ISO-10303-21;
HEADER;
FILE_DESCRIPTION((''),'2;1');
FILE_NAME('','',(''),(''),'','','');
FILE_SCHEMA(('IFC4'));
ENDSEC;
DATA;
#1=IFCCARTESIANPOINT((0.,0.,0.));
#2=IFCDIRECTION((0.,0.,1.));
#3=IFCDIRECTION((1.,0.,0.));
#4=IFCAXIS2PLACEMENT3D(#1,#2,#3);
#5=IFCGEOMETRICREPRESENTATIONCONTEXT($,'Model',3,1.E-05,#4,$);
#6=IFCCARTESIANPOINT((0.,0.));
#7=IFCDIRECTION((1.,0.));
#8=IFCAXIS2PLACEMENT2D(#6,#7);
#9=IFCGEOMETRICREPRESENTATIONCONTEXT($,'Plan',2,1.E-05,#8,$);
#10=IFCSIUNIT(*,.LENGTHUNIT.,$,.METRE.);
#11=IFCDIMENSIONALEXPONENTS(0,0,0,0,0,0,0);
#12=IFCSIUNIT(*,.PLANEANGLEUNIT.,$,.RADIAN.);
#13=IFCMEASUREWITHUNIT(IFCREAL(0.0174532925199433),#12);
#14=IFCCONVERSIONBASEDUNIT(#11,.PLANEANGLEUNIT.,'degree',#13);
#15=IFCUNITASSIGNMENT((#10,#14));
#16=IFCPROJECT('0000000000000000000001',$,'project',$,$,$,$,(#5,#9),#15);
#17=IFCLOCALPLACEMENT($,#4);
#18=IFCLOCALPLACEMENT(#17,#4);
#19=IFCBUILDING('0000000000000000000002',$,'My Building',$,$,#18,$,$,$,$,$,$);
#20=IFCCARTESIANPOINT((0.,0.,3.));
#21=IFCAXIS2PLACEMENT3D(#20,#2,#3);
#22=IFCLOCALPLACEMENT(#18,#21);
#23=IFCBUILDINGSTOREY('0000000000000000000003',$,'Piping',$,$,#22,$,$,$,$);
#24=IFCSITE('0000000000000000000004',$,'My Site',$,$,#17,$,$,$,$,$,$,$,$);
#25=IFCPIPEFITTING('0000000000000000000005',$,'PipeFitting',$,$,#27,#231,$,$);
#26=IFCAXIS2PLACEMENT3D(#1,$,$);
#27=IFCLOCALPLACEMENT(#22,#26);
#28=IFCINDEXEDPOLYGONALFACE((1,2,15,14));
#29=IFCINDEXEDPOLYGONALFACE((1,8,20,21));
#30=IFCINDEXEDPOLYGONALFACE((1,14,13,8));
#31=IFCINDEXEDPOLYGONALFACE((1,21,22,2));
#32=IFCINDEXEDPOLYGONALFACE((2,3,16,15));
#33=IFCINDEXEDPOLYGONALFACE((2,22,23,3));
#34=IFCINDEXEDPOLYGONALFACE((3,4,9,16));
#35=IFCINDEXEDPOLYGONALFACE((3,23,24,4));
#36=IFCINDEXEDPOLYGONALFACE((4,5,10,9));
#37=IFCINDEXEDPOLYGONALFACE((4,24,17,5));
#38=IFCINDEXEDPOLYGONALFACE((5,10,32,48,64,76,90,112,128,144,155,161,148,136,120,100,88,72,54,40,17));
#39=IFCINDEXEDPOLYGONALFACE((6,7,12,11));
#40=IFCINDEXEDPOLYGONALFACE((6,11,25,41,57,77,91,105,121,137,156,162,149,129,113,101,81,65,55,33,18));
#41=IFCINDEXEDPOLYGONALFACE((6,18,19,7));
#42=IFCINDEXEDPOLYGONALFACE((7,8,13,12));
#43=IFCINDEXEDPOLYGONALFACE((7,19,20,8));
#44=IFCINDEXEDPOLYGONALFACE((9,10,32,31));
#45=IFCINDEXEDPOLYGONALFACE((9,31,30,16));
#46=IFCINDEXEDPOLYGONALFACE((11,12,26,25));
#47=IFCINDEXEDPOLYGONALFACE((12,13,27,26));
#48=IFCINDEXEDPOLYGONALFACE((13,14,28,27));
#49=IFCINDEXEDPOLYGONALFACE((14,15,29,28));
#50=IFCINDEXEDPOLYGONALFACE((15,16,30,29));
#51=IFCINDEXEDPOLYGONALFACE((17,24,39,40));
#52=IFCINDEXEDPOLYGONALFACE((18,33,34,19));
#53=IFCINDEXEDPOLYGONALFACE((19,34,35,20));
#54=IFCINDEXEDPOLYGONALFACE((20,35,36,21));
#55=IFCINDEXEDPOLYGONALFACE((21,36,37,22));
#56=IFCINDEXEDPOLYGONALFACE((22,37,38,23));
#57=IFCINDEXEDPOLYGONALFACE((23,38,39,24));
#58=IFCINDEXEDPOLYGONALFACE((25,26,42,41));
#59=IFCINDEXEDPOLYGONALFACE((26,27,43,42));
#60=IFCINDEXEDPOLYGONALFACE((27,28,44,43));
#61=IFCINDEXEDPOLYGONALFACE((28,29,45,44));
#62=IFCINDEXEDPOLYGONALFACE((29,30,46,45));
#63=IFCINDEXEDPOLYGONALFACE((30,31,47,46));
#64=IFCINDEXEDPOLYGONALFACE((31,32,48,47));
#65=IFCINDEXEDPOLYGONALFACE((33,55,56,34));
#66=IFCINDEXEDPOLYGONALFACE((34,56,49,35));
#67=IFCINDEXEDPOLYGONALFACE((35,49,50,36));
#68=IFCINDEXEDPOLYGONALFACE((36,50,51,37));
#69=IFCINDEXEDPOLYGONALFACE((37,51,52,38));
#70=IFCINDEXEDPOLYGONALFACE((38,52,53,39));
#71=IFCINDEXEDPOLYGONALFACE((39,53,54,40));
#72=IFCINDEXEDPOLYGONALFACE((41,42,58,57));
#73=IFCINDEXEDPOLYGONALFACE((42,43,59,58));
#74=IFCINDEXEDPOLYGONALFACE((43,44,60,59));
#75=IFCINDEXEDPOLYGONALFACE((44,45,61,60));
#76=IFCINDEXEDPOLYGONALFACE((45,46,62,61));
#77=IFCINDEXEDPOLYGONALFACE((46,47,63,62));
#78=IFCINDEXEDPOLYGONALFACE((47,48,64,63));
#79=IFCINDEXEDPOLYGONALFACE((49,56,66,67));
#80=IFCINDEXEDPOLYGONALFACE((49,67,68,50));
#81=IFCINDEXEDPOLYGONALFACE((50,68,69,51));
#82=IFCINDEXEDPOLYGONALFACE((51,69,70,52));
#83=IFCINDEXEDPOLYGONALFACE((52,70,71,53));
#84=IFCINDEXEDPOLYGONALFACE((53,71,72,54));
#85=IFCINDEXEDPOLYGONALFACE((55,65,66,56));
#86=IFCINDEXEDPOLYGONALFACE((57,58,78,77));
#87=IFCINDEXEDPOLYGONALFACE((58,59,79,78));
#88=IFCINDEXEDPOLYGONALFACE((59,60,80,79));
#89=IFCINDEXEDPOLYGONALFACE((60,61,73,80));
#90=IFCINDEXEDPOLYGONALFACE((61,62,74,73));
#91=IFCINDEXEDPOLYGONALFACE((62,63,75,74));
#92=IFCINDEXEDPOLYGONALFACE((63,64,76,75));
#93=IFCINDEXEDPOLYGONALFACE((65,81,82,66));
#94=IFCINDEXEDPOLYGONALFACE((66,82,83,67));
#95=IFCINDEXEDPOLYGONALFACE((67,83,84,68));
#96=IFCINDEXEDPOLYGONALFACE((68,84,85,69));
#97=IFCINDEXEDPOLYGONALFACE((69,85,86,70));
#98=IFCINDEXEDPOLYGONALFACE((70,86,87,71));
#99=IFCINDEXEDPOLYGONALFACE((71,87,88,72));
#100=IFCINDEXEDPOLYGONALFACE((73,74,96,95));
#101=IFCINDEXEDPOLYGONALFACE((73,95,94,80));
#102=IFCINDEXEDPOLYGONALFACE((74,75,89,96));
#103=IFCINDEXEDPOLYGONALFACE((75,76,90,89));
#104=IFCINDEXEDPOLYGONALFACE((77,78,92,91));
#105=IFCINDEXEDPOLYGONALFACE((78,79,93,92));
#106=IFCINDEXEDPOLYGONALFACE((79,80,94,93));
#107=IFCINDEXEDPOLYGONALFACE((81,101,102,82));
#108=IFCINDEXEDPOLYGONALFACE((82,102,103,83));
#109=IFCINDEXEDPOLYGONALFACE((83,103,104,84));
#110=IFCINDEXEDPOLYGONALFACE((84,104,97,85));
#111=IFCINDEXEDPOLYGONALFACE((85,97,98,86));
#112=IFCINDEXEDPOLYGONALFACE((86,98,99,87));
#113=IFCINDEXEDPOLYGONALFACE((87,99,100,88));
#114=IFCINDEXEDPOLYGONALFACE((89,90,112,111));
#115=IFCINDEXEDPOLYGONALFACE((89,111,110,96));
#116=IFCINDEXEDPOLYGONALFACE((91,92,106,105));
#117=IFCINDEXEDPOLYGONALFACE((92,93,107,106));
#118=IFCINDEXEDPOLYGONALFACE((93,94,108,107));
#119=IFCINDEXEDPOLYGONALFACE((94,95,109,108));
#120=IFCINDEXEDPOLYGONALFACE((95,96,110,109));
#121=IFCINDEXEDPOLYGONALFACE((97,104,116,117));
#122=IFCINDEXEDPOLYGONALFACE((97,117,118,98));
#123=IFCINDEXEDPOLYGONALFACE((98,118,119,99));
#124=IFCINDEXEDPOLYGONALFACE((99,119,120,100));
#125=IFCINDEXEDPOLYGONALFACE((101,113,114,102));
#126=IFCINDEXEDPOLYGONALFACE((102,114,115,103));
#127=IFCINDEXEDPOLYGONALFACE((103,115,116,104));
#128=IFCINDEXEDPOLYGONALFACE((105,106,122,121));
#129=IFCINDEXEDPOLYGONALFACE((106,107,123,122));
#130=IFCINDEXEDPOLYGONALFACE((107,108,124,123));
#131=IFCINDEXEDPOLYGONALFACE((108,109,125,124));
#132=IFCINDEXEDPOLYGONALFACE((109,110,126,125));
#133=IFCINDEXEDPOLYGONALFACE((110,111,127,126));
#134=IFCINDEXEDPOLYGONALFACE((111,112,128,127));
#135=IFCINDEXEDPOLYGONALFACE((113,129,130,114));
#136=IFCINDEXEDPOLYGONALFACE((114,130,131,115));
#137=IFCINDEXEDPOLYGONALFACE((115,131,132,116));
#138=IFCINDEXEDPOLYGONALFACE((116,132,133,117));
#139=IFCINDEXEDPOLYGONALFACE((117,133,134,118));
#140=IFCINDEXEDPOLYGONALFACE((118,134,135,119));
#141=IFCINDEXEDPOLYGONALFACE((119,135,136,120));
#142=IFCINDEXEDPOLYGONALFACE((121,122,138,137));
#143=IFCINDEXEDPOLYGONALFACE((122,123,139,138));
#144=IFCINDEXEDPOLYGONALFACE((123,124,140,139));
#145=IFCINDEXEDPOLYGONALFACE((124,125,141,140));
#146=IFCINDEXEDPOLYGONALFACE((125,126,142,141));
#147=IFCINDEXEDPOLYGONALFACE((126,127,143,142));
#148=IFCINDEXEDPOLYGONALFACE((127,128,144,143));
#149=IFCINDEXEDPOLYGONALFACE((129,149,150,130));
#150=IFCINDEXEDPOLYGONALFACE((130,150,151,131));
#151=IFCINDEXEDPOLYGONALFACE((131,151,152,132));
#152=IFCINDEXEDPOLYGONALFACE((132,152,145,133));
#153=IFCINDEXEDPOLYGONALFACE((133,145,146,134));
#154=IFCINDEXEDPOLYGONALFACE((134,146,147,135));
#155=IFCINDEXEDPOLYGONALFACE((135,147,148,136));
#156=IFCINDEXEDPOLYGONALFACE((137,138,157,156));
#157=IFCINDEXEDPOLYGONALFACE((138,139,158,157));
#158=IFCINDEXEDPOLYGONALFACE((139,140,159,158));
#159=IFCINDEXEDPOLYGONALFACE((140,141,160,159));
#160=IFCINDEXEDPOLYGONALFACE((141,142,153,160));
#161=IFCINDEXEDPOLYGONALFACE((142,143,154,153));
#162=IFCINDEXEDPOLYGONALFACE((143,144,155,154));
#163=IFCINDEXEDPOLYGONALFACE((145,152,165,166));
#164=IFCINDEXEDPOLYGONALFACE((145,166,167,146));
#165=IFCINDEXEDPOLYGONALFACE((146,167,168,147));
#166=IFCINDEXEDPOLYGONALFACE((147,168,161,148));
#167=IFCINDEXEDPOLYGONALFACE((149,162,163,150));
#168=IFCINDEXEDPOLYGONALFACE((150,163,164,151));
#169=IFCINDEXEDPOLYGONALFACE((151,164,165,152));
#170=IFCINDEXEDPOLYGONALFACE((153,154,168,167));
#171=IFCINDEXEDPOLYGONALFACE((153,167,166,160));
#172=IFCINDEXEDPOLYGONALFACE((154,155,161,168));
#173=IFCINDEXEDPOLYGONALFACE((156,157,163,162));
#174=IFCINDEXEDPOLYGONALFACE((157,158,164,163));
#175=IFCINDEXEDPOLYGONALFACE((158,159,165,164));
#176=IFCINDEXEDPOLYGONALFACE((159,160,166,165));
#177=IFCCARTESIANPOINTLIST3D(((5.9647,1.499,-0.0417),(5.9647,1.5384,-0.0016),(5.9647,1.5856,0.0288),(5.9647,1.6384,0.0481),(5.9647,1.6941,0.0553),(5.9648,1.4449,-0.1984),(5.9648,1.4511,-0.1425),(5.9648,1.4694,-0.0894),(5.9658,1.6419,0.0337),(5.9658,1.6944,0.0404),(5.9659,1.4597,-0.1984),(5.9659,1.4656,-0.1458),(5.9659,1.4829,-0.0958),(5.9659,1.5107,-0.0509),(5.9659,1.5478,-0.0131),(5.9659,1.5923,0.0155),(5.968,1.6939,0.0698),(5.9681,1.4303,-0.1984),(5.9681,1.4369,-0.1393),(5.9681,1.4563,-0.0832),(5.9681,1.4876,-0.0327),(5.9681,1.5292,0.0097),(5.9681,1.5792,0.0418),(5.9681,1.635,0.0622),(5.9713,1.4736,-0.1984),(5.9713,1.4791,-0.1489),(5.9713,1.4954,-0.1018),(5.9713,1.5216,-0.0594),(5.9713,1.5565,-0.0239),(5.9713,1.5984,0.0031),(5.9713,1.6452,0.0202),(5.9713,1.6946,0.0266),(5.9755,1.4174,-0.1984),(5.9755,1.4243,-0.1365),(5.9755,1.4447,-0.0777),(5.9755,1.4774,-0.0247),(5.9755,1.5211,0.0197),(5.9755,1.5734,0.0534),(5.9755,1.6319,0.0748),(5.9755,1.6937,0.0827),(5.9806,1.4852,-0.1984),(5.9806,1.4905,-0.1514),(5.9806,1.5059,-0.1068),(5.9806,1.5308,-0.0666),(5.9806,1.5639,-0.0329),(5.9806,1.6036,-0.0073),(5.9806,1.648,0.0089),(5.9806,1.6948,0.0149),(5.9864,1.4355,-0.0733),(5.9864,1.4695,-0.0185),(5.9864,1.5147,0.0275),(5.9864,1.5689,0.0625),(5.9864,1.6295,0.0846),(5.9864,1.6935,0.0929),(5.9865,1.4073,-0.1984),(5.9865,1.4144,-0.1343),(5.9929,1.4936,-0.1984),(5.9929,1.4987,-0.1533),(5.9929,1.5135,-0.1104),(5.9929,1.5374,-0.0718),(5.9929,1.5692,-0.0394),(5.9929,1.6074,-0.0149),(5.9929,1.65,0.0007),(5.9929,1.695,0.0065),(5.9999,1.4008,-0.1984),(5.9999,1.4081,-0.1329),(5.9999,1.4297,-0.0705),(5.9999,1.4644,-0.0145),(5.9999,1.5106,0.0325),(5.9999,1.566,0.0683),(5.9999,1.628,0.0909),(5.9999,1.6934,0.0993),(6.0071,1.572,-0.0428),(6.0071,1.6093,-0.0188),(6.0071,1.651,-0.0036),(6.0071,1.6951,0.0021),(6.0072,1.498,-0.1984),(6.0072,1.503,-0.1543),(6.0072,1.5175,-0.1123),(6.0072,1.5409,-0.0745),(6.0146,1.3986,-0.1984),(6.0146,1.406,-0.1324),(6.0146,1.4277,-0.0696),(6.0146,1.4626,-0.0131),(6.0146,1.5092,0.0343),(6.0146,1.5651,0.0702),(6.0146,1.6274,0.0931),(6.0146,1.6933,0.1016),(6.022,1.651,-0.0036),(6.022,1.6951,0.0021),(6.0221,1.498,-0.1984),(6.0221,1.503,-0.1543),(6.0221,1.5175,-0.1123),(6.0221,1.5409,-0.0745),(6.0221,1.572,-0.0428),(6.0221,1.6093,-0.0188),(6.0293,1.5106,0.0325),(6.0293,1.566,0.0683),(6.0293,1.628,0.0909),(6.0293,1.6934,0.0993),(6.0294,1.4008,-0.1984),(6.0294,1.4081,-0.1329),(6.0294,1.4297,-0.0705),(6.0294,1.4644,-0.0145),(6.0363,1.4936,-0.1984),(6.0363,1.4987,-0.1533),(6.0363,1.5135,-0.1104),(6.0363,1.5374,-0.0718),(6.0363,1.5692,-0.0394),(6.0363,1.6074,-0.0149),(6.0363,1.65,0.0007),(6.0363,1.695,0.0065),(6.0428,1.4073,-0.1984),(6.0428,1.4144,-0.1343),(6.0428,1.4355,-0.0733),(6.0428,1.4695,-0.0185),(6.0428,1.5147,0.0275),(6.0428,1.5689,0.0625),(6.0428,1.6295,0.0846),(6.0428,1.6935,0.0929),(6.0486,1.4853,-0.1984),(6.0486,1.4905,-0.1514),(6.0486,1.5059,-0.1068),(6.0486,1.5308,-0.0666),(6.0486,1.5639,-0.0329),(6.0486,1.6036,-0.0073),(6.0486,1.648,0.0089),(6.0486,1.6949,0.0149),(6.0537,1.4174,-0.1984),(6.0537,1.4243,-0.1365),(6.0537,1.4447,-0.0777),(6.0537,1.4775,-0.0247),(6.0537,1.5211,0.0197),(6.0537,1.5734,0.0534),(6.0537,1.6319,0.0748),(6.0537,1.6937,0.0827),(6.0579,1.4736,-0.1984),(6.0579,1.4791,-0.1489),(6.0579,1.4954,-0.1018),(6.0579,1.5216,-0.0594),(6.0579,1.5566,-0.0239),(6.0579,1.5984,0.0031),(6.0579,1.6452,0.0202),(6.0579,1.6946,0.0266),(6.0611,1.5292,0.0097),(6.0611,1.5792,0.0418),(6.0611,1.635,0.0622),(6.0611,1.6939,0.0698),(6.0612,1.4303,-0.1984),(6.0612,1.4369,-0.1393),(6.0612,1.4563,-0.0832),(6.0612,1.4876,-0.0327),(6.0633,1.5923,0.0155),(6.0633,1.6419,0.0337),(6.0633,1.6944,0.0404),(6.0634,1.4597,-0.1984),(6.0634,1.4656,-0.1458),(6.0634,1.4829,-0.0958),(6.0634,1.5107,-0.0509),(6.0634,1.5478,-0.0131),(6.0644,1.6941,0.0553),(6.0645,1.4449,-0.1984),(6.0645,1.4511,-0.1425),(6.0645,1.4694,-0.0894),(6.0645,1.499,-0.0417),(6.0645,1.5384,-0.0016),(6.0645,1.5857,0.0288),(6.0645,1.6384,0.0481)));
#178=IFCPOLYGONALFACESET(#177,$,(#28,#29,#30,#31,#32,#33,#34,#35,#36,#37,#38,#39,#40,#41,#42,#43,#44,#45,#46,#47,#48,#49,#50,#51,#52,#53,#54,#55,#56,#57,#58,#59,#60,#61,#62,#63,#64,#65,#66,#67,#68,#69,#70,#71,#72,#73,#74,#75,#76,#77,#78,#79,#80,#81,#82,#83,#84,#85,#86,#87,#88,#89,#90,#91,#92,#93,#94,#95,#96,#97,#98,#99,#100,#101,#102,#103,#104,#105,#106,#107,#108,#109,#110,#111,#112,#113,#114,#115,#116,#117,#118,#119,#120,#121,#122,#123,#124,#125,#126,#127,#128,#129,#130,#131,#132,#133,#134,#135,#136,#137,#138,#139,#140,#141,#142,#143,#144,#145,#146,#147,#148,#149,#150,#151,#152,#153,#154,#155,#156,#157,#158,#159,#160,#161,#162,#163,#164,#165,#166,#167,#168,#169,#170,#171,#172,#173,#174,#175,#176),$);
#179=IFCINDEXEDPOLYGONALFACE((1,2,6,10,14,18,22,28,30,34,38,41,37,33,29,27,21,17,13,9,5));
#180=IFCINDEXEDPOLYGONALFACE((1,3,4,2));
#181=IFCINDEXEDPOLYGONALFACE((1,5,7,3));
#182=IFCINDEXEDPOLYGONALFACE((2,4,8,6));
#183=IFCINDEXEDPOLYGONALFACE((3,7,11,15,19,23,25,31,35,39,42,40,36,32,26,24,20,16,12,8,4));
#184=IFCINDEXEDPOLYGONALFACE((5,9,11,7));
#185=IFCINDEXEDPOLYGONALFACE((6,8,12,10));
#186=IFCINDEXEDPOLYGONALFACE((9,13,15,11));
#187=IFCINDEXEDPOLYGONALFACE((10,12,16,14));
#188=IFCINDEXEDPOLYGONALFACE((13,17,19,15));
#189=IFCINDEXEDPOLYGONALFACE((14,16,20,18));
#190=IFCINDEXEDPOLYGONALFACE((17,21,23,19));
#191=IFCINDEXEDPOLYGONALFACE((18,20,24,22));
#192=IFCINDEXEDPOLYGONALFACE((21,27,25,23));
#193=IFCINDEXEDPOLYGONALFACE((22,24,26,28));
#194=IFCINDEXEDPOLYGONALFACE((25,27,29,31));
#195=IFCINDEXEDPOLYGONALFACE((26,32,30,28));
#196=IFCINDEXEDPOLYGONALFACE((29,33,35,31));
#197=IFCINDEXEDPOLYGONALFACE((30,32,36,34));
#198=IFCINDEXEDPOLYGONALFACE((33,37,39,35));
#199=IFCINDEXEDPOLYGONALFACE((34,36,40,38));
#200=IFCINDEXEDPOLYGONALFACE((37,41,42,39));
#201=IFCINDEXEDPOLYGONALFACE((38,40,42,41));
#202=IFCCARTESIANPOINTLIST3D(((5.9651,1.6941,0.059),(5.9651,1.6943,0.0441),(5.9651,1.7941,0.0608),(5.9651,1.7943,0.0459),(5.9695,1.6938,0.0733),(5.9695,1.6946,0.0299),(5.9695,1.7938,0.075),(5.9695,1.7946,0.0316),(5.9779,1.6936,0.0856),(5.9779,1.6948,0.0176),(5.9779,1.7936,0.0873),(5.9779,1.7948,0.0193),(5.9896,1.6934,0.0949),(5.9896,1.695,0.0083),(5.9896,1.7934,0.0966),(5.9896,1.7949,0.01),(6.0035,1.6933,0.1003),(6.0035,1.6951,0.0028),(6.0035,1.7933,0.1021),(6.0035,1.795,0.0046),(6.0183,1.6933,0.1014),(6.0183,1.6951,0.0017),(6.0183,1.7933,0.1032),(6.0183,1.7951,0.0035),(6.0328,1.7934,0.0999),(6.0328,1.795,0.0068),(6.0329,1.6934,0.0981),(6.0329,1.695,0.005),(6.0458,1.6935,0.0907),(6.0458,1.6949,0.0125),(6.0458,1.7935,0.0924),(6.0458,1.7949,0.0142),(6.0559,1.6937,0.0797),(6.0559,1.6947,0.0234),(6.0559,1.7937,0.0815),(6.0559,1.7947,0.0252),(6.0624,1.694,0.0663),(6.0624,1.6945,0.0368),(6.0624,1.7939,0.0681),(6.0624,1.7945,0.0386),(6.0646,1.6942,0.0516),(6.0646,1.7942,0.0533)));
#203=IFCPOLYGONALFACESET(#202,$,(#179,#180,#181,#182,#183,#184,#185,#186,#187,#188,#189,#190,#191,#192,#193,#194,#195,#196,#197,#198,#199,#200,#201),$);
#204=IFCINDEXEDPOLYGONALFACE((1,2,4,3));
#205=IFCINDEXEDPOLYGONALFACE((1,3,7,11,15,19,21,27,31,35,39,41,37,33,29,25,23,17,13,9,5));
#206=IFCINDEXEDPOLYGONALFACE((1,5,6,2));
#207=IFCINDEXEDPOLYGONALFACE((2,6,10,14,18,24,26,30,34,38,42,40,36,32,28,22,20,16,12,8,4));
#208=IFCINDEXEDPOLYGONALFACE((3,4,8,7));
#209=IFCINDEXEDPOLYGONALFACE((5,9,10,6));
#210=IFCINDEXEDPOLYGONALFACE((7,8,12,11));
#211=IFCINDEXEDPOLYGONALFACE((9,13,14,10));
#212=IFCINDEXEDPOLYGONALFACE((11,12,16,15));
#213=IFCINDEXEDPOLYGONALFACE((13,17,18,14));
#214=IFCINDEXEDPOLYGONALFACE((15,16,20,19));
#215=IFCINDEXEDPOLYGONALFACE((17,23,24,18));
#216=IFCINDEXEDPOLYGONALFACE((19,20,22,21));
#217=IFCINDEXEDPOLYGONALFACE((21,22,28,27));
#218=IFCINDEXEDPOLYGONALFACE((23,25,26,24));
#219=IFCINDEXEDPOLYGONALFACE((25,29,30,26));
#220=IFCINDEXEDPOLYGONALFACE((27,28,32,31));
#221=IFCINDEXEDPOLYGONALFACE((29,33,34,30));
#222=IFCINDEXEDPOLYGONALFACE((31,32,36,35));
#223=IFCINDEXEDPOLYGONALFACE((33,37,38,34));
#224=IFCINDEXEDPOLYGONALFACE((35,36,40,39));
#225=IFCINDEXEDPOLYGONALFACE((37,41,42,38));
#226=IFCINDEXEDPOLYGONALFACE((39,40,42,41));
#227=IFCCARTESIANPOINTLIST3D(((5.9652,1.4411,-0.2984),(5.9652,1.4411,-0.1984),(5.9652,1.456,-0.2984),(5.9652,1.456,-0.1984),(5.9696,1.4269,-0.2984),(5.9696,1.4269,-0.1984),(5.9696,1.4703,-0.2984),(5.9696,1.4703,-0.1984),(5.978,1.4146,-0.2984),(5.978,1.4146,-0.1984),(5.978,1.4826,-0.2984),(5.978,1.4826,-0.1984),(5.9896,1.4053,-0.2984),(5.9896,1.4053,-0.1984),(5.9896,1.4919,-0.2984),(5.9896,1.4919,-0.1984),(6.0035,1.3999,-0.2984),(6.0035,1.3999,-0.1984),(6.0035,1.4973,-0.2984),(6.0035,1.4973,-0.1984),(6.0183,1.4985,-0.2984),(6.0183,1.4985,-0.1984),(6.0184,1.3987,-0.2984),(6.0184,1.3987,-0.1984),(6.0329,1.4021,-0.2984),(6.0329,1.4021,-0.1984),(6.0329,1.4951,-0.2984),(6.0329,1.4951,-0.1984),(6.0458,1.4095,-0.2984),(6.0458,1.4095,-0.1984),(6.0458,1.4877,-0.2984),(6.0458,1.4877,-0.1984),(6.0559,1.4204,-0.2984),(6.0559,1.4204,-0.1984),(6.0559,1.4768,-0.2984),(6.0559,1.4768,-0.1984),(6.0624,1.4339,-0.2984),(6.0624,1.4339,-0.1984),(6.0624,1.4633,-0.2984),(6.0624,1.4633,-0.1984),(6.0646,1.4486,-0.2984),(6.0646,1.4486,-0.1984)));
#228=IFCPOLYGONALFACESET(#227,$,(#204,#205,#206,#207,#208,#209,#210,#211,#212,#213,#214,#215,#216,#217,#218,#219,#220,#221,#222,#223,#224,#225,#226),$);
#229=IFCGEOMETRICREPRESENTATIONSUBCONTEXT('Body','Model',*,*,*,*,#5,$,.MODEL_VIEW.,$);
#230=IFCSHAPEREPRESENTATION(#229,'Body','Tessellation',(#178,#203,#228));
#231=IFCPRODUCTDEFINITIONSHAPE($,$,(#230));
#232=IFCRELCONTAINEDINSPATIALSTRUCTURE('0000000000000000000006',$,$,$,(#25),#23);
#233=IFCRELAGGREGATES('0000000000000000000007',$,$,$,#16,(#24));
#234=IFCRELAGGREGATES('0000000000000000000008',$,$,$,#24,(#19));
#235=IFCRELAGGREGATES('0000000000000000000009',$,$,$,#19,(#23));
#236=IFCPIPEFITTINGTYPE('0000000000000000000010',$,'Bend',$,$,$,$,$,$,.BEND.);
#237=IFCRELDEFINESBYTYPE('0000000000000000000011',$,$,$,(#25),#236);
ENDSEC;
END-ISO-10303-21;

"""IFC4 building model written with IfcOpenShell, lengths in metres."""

from ifc_helpers import new_model, entity, si_unit, converted_unit, frame, origin_with_axes, origin_2d_with_axis, place, context, subcontext, project, spatial, circle, extrude, source, transform, mapped, type_object, type_shapes, element, save


model = new_model("IFC4")

# Units and contexts
model_context = context("Model", 3, precision=1e-05, world=origin_with_axes())
plan_context = context("Plan", 2, precision=1e-05, world=origin_2d_with_axis())
body_context = subcontext(model_context, "Body", "Model", "MODEL_VIEW")
ifc_project = project(units=[si_unit("LENGTHUNIT", "METRE"), converted_unit("PLANEANGLEUNIT", "degree", entity("IfcReal", 0.0174532925199433), si_unit("PLANEANGLEUNIT", "RADIAN"), dimensions=[0, 0, 0, 0, 0, 0, 0])], contexts=[model_context, plan_context])

# Site, building, storey
site_placement = place(None, origin_with_axes())
site = spatial("IfcSite", under=ifc_project, at=site_placement, Name="My Site")
building_placement = place(site_placement, origin_with_axes())
building = spatial("IfcBuilding", under=site, at=building_placement, Name="My Building")
storey_placement = place(building_placement, frame((0.0, 0.0, 3.0), z_axis=(0.0, 0.0, 1.0), x_axis=(1.0, 0.0, 0.0)))
storey = spatial("IfcBuildingStorey", under=building, at=storey_placement, Name="Piping")

# Pipe fitting
pipe_fitting_type_1 = type_object("IfcPipeFittingType", Name="Bend", PredefinedType="BEND")
shared_shape_1 = source(origin_with_axes(), body_context, "Body", "SolidModel", [
    entity("IfcSweptDiskSolid", entity("IfcIndexedPolyCurve", entity("IfcCartesianPointList3D", [[0.0, 0.0, 0.1], [0.0, -0.0717, 0.2752], [0.0, -0.2456, 0.35]]), [entity("IfcArcIndex", [1, 2, 3])]), 0.05),
    extrude(circle(Radius=0.05), origin_with_axes(), (0.0, 0.0, 1.0), 0.1),
    extrude(circle(Radius=0.05), frame((0.0, -0.2456, 0.35), z_axis=(0.0, -0.999846, 0.017575), x_axis=(1.0, 0.0, 0.0)), (0.0, 0.0, 1.0), 0.1),
])
type_shapes(pipe_fitting_type_1, [shared_shape_1])
for number, where, z_axis, x_axis, name in (
    (1, (6.0146, 1.7942, 0.0533), (0.000099, -0.999846, -0.017575), (1.0, 0.000099, -0.000001), "PipeFitting"),
):
    element("IfcPipeFitting", number, at=place(storey_placement, frame(where, z_axis=z_axis, x_axis=x_axis)), inside=storey, type_object=pipe_fitting_type_1, Name=name, context=body_context, shape_type="MappedRepresentation", body=[
        mapped(shared_shape_1, transform((0.0, 0.0, 0.0), x_axis=(1.0, 0.0, 0.0), y_axis=(0.0, 1.0, 0.0), z_axis=(0.0, 0.0, 1.0), scale=1.0)),
    ])

save(model, "model.ifc")
